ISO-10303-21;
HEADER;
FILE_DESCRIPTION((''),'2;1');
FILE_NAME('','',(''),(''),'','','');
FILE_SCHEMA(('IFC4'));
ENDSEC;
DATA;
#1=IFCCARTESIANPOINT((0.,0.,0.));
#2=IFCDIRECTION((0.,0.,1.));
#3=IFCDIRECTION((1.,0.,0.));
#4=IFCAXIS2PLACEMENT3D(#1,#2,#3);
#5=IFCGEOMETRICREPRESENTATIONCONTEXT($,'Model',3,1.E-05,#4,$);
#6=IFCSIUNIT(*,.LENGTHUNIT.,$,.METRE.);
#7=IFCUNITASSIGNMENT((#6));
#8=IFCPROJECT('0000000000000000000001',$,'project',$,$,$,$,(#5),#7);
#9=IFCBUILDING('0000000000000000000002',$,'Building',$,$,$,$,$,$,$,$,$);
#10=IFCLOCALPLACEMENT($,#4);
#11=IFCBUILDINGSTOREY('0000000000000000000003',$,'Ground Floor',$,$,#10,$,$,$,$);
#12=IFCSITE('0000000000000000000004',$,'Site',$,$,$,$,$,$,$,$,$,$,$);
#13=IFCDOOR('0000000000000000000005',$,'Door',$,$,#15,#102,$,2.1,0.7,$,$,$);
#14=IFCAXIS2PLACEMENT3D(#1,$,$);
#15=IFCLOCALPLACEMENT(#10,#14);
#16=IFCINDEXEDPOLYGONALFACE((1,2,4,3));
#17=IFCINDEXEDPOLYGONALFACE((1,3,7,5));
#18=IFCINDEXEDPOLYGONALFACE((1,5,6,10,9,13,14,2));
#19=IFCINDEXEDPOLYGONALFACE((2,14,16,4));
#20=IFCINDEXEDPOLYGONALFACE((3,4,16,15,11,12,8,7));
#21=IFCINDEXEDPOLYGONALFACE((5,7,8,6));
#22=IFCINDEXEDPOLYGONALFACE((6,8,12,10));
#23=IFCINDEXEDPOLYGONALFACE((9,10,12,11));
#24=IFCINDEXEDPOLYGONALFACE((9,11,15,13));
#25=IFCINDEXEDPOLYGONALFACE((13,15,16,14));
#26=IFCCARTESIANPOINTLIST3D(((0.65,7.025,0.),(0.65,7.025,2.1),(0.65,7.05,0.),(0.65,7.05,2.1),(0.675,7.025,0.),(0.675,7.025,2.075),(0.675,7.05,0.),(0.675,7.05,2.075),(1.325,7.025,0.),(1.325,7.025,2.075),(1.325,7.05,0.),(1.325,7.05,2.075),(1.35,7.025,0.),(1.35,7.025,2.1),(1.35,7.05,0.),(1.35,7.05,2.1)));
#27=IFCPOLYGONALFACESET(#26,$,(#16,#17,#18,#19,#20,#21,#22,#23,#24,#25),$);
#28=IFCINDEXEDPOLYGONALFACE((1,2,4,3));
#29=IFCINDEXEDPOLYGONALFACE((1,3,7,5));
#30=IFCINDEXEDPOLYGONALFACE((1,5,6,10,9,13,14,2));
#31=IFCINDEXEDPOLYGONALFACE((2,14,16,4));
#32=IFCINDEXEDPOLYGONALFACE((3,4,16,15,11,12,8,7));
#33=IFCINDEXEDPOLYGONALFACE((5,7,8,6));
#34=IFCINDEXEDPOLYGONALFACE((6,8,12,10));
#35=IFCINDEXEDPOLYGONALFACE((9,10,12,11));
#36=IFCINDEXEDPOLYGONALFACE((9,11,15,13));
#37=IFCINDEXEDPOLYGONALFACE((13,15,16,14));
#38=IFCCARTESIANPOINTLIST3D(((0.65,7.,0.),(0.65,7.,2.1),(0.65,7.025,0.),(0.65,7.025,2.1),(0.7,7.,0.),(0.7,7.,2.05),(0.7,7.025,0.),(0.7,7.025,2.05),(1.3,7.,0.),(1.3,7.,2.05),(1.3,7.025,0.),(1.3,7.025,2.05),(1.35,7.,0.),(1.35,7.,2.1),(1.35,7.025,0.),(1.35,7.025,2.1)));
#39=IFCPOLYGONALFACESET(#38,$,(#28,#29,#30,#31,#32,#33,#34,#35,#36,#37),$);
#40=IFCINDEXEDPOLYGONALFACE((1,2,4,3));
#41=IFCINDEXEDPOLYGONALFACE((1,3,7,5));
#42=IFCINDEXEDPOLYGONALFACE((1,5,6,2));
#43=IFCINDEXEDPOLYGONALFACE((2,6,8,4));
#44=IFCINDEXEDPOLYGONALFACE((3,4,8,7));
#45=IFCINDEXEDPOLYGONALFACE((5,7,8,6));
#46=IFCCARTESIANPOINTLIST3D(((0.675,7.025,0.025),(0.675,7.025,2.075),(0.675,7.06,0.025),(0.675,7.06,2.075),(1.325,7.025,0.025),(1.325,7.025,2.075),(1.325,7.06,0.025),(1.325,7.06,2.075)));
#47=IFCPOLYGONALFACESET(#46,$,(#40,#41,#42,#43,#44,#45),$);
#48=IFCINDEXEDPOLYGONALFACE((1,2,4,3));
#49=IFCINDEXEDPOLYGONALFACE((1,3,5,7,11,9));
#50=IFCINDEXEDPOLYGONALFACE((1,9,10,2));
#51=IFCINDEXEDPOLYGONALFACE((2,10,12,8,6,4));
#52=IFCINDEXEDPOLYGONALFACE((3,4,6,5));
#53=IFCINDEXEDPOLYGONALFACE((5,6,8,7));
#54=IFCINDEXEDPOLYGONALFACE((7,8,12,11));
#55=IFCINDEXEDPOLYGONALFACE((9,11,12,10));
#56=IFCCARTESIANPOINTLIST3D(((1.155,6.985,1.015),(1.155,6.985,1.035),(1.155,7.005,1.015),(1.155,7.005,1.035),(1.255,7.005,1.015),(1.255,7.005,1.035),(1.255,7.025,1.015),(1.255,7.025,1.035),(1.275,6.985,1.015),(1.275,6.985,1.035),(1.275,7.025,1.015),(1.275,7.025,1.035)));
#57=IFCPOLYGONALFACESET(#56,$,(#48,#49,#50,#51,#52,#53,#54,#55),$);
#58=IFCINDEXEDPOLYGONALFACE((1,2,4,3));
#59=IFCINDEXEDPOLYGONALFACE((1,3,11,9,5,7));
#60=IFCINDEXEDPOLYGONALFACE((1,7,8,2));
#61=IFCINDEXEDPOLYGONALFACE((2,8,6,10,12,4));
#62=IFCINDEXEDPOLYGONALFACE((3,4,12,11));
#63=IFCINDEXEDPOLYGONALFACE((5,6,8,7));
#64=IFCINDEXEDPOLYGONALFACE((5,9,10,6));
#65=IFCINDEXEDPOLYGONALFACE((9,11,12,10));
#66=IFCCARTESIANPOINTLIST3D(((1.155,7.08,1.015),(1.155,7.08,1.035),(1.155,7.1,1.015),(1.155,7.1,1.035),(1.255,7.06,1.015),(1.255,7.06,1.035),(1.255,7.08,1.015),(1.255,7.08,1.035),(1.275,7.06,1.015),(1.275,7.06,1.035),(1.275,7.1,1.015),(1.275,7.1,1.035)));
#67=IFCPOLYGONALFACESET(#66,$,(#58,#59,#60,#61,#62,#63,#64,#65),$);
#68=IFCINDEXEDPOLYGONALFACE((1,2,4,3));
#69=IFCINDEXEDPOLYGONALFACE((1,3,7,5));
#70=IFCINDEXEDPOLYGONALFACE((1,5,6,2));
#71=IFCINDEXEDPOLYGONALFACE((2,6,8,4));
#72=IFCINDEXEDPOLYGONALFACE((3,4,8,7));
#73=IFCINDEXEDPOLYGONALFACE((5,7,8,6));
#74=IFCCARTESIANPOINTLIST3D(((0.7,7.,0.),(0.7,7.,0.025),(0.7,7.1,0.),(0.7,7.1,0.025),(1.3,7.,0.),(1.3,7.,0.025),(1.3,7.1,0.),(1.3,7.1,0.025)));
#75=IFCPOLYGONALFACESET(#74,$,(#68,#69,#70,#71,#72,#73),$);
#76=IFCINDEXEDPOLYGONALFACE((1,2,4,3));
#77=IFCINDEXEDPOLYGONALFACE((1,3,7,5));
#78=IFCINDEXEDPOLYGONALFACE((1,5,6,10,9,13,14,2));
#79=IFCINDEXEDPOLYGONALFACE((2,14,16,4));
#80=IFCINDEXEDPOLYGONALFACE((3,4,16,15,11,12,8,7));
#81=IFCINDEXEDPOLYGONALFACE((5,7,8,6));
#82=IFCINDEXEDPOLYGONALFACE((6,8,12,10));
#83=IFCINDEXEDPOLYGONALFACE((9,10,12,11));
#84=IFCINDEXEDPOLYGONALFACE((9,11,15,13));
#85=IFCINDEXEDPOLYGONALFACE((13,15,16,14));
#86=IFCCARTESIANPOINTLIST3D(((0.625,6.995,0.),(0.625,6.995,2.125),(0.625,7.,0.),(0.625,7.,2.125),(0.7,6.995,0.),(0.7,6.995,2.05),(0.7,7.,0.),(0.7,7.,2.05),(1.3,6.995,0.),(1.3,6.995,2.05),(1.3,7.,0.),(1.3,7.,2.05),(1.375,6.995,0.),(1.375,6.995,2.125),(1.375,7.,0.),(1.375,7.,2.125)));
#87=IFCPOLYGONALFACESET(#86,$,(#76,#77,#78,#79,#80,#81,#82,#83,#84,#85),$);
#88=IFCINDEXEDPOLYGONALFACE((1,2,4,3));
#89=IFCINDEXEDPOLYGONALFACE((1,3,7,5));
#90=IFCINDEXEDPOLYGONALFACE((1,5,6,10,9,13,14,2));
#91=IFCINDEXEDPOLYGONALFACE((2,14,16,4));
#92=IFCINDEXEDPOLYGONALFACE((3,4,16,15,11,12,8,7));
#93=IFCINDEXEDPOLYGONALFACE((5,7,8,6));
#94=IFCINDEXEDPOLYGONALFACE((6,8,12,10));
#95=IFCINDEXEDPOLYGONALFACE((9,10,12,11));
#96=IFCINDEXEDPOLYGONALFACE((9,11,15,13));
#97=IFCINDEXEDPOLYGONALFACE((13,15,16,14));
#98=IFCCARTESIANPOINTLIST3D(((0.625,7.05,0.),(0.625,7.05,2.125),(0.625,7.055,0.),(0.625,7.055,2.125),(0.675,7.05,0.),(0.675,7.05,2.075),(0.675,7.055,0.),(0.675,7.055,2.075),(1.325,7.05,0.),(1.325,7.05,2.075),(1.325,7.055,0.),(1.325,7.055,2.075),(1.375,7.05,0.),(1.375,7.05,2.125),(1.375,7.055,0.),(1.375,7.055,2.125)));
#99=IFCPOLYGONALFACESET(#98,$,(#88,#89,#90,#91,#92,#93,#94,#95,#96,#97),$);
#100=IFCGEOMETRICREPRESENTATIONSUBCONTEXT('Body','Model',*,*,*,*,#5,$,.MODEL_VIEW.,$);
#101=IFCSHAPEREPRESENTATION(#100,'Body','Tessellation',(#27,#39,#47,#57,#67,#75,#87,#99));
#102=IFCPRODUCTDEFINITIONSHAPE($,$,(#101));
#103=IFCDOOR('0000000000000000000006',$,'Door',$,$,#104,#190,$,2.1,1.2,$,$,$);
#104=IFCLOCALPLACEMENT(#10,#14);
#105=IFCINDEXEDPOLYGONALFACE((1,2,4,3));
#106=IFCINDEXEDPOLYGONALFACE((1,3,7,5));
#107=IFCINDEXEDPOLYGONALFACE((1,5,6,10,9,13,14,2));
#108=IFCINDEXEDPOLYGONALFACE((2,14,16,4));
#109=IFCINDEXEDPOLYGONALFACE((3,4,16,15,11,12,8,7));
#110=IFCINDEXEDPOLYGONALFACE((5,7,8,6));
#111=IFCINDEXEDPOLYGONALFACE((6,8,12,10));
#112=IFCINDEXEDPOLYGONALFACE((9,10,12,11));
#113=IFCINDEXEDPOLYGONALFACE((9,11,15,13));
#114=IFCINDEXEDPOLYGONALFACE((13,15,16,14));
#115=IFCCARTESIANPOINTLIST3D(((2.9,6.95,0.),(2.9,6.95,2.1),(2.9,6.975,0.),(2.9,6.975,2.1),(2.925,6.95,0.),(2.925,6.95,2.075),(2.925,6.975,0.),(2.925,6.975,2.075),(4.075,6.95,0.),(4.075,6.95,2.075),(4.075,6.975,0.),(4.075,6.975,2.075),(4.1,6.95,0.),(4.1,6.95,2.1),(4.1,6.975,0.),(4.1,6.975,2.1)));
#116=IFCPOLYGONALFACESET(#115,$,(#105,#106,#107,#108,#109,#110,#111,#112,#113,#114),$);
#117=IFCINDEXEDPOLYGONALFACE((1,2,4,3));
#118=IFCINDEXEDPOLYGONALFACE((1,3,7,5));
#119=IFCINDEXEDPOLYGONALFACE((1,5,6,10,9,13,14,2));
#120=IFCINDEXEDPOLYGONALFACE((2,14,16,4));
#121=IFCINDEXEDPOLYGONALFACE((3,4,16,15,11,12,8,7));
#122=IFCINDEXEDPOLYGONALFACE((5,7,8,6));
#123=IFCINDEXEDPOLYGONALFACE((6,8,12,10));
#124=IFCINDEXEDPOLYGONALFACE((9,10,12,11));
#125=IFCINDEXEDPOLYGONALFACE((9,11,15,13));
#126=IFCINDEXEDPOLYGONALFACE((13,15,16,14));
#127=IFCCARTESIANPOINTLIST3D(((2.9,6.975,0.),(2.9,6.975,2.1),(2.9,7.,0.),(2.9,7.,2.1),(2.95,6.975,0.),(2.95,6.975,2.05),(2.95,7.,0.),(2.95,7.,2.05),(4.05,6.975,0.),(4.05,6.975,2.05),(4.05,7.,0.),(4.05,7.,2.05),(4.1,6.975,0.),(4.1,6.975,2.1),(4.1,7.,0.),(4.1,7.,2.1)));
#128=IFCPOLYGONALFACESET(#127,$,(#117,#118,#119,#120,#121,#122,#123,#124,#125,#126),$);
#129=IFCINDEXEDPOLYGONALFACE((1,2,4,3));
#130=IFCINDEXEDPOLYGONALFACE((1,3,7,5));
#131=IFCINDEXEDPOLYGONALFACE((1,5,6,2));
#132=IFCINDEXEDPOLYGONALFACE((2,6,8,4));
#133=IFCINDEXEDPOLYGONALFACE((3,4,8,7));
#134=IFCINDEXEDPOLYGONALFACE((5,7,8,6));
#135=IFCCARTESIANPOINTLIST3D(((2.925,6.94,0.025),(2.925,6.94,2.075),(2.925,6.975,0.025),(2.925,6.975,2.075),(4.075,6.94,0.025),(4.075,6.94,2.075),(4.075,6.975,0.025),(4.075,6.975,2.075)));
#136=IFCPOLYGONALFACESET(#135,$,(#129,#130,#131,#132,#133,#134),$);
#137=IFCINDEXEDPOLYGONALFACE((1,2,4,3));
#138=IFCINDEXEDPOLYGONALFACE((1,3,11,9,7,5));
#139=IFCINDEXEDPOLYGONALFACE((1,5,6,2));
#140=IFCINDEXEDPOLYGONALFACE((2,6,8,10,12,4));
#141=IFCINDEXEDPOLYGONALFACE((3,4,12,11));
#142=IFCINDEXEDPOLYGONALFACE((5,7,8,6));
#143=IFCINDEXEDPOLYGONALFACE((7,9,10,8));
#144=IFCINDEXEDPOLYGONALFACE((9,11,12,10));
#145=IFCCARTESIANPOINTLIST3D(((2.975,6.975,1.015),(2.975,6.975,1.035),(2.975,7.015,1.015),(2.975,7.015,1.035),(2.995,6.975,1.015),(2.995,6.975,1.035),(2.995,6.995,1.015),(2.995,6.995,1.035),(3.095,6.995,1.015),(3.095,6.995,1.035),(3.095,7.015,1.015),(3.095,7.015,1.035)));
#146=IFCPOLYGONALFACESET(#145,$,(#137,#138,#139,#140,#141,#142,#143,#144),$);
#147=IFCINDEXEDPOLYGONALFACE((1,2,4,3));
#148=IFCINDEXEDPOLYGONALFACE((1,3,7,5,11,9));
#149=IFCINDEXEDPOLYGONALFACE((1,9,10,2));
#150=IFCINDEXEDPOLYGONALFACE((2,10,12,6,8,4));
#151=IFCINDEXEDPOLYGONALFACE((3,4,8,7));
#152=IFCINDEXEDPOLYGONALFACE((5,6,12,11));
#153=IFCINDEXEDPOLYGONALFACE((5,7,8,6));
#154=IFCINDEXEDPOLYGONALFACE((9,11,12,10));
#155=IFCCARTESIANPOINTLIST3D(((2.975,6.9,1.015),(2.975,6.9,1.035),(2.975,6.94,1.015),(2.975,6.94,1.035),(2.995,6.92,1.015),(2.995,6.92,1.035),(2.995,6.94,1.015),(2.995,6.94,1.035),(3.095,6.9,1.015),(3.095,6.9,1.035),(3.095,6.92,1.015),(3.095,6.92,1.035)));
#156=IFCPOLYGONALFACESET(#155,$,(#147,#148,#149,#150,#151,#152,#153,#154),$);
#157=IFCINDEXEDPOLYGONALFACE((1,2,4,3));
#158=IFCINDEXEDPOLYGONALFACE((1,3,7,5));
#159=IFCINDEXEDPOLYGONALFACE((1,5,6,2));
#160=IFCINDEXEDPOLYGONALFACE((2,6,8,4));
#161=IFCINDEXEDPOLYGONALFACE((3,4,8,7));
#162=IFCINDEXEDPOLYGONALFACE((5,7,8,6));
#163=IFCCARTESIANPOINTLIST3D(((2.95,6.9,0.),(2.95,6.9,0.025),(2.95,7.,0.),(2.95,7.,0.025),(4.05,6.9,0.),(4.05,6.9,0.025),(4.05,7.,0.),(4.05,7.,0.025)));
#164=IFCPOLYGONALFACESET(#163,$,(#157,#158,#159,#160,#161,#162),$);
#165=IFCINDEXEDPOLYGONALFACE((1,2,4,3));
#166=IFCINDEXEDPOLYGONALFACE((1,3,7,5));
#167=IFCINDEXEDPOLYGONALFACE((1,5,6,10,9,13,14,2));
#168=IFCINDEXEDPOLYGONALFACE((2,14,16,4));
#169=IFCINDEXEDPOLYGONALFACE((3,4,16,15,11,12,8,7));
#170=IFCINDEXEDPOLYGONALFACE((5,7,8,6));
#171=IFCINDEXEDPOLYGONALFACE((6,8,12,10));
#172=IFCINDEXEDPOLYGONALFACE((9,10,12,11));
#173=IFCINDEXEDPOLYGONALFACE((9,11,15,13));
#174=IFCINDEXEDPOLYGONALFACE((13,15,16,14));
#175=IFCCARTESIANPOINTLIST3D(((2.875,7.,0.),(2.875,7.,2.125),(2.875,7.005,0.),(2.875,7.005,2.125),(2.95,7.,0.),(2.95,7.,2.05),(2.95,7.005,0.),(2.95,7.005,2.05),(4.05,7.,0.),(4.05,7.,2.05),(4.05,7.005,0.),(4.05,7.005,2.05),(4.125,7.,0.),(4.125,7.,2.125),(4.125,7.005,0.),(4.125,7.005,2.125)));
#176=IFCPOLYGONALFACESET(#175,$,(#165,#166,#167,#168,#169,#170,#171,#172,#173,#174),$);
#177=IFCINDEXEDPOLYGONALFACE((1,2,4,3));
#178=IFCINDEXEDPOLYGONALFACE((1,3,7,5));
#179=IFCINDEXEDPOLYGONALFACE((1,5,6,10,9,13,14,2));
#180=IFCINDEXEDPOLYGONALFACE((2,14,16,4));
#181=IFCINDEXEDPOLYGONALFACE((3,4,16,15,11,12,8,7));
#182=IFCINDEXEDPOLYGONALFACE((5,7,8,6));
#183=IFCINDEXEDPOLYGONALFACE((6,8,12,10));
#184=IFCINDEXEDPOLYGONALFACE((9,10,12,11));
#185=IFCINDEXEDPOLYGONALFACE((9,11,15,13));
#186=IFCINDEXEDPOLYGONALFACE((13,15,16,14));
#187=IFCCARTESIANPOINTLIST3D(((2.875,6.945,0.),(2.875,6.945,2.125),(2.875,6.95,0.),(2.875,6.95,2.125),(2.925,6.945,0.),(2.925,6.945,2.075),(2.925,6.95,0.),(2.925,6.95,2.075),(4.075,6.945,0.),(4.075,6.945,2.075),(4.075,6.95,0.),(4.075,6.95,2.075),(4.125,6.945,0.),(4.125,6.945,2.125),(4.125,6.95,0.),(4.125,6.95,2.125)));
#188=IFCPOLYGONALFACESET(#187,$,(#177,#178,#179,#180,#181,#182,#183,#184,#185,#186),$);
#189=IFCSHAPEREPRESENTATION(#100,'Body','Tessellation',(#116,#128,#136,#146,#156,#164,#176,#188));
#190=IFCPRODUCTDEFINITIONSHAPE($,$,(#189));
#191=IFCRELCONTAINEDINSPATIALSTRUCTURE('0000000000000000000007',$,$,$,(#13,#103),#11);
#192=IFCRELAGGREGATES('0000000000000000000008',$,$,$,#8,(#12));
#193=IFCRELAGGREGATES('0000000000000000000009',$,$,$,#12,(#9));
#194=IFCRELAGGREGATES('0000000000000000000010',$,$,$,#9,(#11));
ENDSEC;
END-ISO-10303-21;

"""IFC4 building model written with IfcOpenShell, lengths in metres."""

from ifc_helpers import new_model, si_unit, frame, origin_with_axes, place, context, subcontext, project, spatial, line, indexed_curve, outline, extrude, element, save


model = new_model("IFC4")

# Units and contexts
model_context = context("Model", 3, precision=1e-05, world=origin_with_axes())
body_context = subcontext(model_context, "Body", "Model", "MODEL_VIEW")
ifc_project = project(units=[si_unit("LENGTHUNIT", "METRE")], contexts=[model_context])

# Site, building, storey
site = spatial("IfcSite", under=ifc_project, Name="Site")
building = spatial("IfcBuilding", under=site, Name="Building")
storey_placement = place(None, origin_with_axes())
storey = spatial("IfcBuildingStorey", under=building, at=storey_placement, Name="Ground Floor")

# Doors
door_1_placement = place(storey_placement, frame((0.65, 7.0, 0.0), z_axis=(0.0, 0.0, 1.0), x_axis=(1.0, 0.0, 0.0)))
element("IfcDoor", 1, at=door_1_placement, inside=storey, Name="Door", OverallHeight=2.1, OverallWidth=0.7, context=body_context, shape_type="SweptSolid", body=[
    extrude(outline(indexed_curve([(0.0, 0.0), (0.0, 2.1), (0.7, 2.1), (0.7, 0.0), (0.675, 0.0), (0.675, 2.075), (0.025, 2.075), (0.025, 0.0)], segments=[line(1, 2, 3, 4, 5, 6, 7, 8, 1)])), frame((0.0, 0.025, 0.0), z_axis=(0.0, -1.0, 0.0), x_axis=(1.0, 0.0, 0.0)), (0.0, 0.0, -1.0), 0.025),
    extrude(outline(indexed_curve([(0.0, 0.0), (0.0, 2.1), (0.7, 2.1), (0.7, 0.0), (0.65, 0.0), (0.65, 2.05), (0.05, 2.05), (0.05, 0.0)], segments=[line(1, 2, 3, 4, 5, 6, 7, 8, 1)])), frame((0.0, 0.0, 0.0), z_axis=(0.0, -1.0, 0.0), x_axis=(1.0, 0.0, 0.0)), (0.0, 0.0, -1.0), 0.025),
    extrude(outline(indexed_curve([(0.0, 0.0), (0.65, 0.0), (0.65, 0.035), (0.0, 0.035)], segments=[line(1, 2, 3, 4, 1)])), frame((0.025, 0.025, 0.025), z_axis=(0.0, 0.0, 1.0), x_axis=(1.0, 0.0, 0.0)), (0.0, 0.0, 1.0), 2.05),
    extrude(outline(indexed_curve([(0.0, 0.0), (0.0, -0.04), (-0.12, -0.04), (-0.12, -0.02), (-0.02, -0.02), (-0.02, 0.0)], segments=[line(1, 2, 3, 4, 5, 6, 1)])), frame((0.625, 0.025, 1.015), z_axis=(0.0, 0.0, 1.0), x_axis=(1.0, 0.0, 0.0)), (0.0, 0.0, 1.0), 0.02),
    extrude(outline(indexed_curve([(0.0, 0.0), (0.0, 0.04), (-0.12, 0.04), (-0.12, 0.02), (-0.02, 0.02), (-0.02, 0.0)], segments=[line(1, 2, 3, 4, 5, 6, 1)])), frame((0.625, 0.06, 1.015), z_axis=(0.0, 0.0, 1.0), x_axis=(1.0, 0.0, 0.0)), (0.0, 0.0, 1.0), 0.02),
    extrude(outline(indexed_curve([(0.0, 0.0), (0.6, 0.0), (0.6, 0.1), (0.0, 0.1)], segments=[line(1, 2, 3, 4, 1)])), frame((0.05, 0.0, 0.0), z_axis=(0.0, 0.0, 1.0), x_axis=(1.0, 0.0, 0.0)), (0.0, 0.0, 1.0), 0.025),
    extrude(outline(indexed_curve([(0.0, 0.0), (0.0, 2.125), (0.75, 2.125), (0.75, 0.0), (0.675, 0.0), (0.675, 2.05), (0.075, 2.05), (0.075, 0.0)], segments=[line(1, 2, 3, 4, 5, 6, 7, 8, 1)])), frame((-0.025, -0.005, 0.0), z_axis=(0.0, -1.0, 0.0), x_axis=(1.0, 0.0, 0.0)), (0.0, 0.0, -1.0), 0.005),
    extrude(outline(indexed_curve([(0.0, 0.0), (0.0, 2.125), (0.75, 2.125), (0.75, 0.0), (0.7, 0.0), (0.7, 2.075), (0.05, 2.075), (0.05, 0.0)], segments=[line(1, 2, 3, 4, 5, 6, 7, 8, 1)])), frame((-0.025, 0.05, 0.0), z_axis=(0.0, -1.0, 0.0), x_axis=(1.0, 0.0, 0.0)), (0.0, 0.0, -1.0), 0.005),
])
door_2_placement = place(storey_placement, frame((4.1, 7.0, 0.0), z_axis=(0.0, 0.0, 1.0), x_axis=(-1.0, 0.0, 0.0)))
element("IfcDoor", 2, at=door_2_placement, inside=storey, Name="Door", OverallHeight=2.1, OverallWidth=1.2, context=body_context, shape_type="SweptSolid", body=[
    extrude(outline(indexed_curve([(0.0, 0.0), (0.0, 2.1), (1.2, 2.1), (1.2, 0.0), (1.175, 0.0), (1.175, 2.075), (0.025, 2.075), (0.025, 0.0)], segments=[line(1, 2, 3, 4, 5, 6, 7, 8, 1)])), frame((0.0, 0.025, 0.0), z_axis=(0.0, -1.0, 0.0), x_axis=(1.0, 0.0, 0.0)), (0.0, 0.0, -1.0), 0.025),
    extrude(outline(indexed_curve([(0.0, 0.0), (0.0, 2.1), (1.2, 2.1), (1.2, 0.0), (1.15, 0.0), (1.15, 2.05), (0.05, 2.05), (0.05, 0.0)], segments=[line(1, 2, 3, 4, 5, 6, 7, 8, 1)])), frame((0.0, 0.0, 0.0), z_axis=(0.0, -1.0, 0.0), x_axis=(1.0, 0.0, 0.0)), (0.0, 0.0, -1.0), 0.025),
    extrude(outline(indexed_curve([(0.0, 0.0), (1.15, 0.0), (1.15, 0.035), (0.0, 0.035)], segments=[line(1, 2, 3, 4, 1)])), frame((0.025, 0.025, 0.025), z_axis=(0.0, 0.0, 1.0), x_axis=(1.0, 0.0, 0.0)), (0.0, 0.0, 1.0), 2.05),
    extrude(outline(indexed_curve([(0.0, 0.0), (0.0, -0.04), (-0.12, -0.04), (-0.12, -0.02), (-0.02, -0.02), (-0.02, 0.0)], segments=[line(1, 2, 3, 4, 5, 6, 1)])), frame((1.125, 0.025, 1.015), z_axis=(0.0, 0.0, 1.0), x_axis=(1.0, 0.0, 0.0)), (0.0, 0.0, 1.0), 0.02),
    extrude(outline(indexed_curve([(0.0, 0.0), (0.0, 0.04), (-0.12, 0.04), (-0.12, 0.02), (-0.02, 0.02), (-0.02, 0.0)], segments=[line(1, 2, 3, 4, 5, 6, 1)])), frame((1.125, 0.06, 1.015), z_axis=(0.0, 0.0, 1.0), x_axis=(1.0, 0.0, 0.0)), (0.0, 0.0, 1.0), 0.02),
    extrude(outline(indexed_curve([(0.0, 0.0), (1.1, 0.0), (1.1, 0.1), (0.0, 0.1)], segments=[line(1, 2, 3, 4, 1)])), frame((0.05, 0.0, 0.0), z_axis=(0.0, 0.0, 1.0), x_axis=(1.0, 0.0, 0.0)), (0.0, 0.0, 1.0), 0.025),
    extrude(outline(indexed_curve([(0.0, 0.0), (0.0, 2.125), (1.25, 2.125), (1.25, 0.0), (1.175, 0.0), (1.175, 2.05), (0.075, 2.05), (0.075, 0.0)], segments=[line(1, 2, 3, 4, 5, 6, 7, 8, 1)])), frame((-0.025, -0.005, 0.0), z_axis=(0.0, -1.0, 0.0), x_axis=(1.0, 0.0, 0.0)), (0.0, 0.0, -1.0), 0.005),
    extrude(outline(indexed_curve([(0.0, 0.0), (0.0, 2.125), (1.25, 2.125), (1.25, 0.0), (1.2, 0.0), (1.2, 2.075), (0.05, 2.075), (0.05, 0.0)], segments=[line(1, 2, 3, 4, 5, 6, 7, 8, 1)])), frame((-0.025, 0.05, 0.0), z_axis=(0.0, -1.0, 0.0), x_axis=(1.0, 0.0, 0.0)), (0.0, 0.0, -1.0), 0.005),
])

save(model, "model.ifc")
